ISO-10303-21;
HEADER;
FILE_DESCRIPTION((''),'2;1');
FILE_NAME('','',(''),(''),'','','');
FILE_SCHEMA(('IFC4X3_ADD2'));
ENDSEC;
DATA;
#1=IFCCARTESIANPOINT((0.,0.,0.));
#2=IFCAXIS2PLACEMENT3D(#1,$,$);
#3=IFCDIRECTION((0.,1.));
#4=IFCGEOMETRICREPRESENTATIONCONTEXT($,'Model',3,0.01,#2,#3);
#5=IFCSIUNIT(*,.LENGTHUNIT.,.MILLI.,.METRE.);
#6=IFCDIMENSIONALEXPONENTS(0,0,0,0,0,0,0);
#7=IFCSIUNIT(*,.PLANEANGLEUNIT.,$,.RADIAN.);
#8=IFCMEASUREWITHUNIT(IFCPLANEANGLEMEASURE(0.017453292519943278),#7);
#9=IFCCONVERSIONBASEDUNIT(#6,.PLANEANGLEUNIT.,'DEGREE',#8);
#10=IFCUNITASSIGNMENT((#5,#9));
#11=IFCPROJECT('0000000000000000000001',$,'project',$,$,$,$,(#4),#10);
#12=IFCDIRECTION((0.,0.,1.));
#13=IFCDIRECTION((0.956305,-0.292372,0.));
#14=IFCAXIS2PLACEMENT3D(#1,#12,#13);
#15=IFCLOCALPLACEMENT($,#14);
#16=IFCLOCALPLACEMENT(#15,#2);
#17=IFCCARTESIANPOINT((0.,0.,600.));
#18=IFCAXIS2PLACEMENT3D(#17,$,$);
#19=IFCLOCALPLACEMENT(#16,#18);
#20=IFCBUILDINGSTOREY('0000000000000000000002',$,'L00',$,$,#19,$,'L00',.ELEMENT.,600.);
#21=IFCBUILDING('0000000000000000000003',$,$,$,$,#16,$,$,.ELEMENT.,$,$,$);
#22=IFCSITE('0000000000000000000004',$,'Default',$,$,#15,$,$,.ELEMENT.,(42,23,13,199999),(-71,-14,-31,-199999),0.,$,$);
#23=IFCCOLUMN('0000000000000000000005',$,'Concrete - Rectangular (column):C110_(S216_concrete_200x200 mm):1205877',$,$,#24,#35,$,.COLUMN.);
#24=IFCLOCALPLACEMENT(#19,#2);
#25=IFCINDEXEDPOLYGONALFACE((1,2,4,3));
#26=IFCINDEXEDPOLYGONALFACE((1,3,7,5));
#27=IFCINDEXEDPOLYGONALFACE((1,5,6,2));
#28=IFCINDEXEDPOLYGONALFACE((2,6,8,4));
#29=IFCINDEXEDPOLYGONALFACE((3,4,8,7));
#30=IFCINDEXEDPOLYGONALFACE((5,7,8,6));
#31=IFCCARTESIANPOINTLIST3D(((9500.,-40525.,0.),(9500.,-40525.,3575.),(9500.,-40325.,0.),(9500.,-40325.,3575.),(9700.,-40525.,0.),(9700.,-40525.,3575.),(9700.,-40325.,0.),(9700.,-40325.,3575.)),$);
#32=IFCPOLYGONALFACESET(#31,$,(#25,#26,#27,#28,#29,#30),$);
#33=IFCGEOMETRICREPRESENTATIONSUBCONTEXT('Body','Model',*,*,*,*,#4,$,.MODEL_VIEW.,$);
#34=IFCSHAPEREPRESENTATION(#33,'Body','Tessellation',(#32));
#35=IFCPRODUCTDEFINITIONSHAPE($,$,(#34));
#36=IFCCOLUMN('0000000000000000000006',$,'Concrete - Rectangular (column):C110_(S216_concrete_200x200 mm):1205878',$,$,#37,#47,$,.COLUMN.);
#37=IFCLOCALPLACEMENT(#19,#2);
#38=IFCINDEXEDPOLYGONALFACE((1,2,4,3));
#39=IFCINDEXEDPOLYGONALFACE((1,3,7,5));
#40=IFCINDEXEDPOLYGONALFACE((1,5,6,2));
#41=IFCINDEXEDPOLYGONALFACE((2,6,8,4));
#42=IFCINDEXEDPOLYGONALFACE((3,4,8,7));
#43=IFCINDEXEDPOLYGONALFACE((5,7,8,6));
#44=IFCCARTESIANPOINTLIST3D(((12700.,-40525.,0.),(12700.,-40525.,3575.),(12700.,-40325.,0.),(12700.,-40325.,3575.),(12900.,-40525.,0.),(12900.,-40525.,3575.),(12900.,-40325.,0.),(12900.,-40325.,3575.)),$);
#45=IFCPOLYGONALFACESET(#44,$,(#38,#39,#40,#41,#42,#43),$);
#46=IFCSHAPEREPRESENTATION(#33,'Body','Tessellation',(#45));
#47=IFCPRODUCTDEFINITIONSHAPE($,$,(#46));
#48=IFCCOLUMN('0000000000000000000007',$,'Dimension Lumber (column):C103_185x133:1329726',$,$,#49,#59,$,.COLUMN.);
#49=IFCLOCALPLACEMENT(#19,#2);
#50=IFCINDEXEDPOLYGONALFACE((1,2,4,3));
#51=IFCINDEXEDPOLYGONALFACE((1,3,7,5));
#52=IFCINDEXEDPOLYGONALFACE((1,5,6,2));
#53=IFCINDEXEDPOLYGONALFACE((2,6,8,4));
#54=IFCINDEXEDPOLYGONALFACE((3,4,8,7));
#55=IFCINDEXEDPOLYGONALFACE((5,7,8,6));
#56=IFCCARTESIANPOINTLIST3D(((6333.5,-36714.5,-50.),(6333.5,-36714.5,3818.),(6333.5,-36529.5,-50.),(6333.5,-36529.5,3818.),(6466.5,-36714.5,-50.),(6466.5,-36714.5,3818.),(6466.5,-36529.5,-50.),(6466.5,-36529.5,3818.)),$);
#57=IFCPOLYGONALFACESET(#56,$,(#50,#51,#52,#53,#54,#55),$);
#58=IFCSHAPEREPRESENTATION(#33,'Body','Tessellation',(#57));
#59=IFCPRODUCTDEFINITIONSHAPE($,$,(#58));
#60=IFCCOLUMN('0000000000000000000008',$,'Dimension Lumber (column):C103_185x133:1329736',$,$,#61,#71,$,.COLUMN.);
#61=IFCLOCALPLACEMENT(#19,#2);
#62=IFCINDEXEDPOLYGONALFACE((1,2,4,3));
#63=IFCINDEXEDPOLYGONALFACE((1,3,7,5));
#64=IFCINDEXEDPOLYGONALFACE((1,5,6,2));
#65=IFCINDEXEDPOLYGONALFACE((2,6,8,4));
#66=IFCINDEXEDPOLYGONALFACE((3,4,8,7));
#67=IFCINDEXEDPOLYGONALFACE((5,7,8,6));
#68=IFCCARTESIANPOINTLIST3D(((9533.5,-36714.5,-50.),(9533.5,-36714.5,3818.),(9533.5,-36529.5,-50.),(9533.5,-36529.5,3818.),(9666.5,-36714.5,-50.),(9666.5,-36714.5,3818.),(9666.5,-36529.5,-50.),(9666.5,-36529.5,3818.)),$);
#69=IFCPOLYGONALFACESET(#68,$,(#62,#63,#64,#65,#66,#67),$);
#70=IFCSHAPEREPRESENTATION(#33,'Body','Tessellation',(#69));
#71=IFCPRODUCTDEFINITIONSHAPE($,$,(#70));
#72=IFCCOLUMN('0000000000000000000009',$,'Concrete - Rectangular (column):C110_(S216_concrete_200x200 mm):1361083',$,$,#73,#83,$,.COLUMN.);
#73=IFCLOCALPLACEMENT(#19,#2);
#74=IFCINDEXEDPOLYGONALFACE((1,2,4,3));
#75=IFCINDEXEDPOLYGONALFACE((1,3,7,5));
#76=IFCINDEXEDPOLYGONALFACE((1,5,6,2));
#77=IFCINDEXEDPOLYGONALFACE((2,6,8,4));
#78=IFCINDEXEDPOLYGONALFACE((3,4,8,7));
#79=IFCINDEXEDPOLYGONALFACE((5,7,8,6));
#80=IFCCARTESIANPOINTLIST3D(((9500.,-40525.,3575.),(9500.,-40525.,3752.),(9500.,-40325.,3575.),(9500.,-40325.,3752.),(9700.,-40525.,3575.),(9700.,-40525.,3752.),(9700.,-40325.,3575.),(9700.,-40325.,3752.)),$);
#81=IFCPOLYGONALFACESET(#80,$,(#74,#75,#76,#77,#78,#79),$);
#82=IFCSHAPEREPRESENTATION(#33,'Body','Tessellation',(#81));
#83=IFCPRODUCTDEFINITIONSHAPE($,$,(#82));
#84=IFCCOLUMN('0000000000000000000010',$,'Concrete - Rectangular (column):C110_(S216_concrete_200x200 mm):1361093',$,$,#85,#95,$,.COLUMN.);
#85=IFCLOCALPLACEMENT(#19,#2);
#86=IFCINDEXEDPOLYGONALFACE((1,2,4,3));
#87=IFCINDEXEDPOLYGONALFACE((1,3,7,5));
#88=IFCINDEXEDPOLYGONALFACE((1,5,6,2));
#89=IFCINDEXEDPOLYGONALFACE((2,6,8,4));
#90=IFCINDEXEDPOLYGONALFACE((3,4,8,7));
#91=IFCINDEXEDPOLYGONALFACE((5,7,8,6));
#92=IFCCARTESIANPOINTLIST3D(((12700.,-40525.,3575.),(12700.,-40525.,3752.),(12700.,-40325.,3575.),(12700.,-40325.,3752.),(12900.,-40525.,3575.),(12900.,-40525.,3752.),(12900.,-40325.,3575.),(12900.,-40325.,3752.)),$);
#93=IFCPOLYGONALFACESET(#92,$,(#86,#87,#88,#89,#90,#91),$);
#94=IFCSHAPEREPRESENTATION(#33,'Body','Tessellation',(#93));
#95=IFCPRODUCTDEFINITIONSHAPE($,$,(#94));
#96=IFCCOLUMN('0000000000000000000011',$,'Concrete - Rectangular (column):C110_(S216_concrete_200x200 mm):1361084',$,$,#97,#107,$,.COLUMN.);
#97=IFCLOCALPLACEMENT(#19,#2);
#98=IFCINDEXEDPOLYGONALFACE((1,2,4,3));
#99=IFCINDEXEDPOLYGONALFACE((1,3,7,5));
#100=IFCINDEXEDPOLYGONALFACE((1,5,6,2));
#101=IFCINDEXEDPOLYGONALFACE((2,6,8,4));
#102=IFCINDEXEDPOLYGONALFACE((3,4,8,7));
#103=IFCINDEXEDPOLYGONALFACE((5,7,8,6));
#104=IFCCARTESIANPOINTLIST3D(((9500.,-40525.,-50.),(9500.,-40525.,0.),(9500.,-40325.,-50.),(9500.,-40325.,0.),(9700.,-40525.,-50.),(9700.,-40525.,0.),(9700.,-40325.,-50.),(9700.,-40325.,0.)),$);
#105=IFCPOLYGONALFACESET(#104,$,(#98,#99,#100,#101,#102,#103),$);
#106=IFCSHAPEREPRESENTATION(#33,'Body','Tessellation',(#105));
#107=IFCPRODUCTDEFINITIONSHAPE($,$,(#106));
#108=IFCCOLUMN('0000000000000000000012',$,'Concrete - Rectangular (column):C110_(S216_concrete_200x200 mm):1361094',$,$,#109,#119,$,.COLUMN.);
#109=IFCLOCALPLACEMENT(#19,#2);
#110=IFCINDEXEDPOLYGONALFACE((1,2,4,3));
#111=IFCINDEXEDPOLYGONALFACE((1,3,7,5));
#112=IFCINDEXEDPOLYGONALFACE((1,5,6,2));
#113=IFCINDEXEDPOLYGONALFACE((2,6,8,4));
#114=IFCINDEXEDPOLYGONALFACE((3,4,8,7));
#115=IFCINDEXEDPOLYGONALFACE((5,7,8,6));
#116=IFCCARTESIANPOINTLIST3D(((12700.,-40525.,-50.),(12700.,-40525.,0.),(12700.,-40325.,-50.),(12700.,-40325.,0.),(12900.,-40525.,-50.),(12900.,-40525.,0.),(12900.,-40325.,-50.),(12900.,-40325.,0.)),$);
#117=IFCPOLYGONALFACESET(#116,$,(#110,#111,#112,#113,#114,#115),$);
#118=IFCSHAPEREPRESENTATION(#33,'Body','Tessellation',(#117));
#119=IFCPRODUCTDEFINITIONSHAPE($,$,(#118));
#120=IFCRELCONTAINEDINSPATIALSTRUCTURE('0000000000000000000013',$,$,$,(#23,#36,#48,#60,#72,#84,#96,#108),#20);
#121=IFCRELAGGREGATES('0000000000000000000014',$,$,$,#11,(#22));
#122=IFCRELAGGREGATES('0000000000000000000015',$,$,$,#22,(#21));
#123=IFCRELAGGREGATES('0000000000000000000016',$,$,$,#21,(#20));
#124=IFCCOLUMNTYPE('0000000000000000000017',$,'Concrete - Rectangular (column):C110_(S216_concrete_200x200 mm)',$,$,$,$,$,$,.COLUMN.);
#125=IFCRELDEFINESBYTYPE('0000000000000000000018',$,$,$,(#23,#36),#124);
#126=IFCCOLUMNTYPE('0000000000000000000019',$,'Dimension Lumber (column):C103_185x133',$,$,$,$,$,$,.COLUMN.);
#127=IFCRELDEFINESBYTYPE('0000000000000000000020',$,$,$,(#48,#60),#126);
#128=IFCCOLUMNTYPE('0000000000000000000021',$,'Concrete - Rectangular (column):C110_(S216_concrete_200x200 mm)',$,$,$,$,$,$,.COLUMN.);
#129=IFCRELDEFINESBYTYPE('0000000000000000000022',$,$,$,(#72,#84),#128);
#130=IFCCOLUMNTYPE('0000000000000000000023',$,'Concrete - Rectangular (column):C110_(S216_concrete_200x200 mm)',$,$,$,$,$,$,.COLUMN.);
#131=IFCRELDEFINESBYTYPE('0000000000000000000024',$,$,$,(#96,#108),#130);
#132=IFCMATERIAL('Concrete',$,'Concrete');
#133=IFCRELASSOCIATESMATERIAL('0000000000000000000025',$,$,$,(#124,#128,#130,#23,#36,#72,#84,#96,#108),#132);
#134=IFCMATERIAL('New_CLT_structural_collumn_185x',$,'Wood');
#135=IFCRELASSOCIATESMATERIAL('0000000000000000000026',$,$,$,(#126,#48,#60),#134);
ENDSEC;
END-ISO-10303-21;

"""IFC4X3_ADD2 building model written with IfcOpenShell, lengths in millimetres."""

from ifc_helpers import new_model, entity, si_unit, converted_unit, direction, frame, origin, origin_2d_with_axis, place, context, subcontext, project, spatial, rectangle, extrude, source, transform, mapped, material, material_profile, profile_set, profile_usage, type_object, type_shapes, element, save


model = new_model("IFC4X3_ADD2")

# Units and contexts
model_context = context("Model", 3, precision=0.01, world=origin(), true_north=direction((0.0, 1.0)))
body_context = subcontext(model_context, "Body", "Model", "MODEL_VIEW")
ifc_project = project(units=[si_unit("LENGTHUNIT", "METRE", prefix="MILLI"), converted_unit("PLANEANGLEUNIT", "DEGREE", entity("IfcPlaneAngleMeasure", 0.017453292519943278), si_unit("PLANEANGLEUNIT", "RADIAN"), dimensions=[0, 0, 0, 0, 0, 0, 0])], contexts=[model_context])

# Site, building, storey
site_placement = place(None, frame((0.0, 0.0, 0.0), z_axis=(0.0, 0.0, 1.0), x_axis=(0.956305, -0.292372, 0.0)))
site = spatial("IfcSite", under=ifc_project, at=site_placement, Name="Default", CompositionType="ELEMENT", RefLatitude=(42, 23, 13, 199999), RefLongitude=(-71, -14, -31, -199999), RefElevation=0.0)
building_placement = place(site_placement, origin())
building = spatial("IfcBuilding", under=site, at=building_placement, CompositionType="ELEMENT")
storey_placement = place(building_placement, frame((0.0, 0.0, 600.0)))
storey = spatial("IfcBuildingStorey", under=building, at=storey_placement, Name="L00", LongName="L00", CompositionType="ELEMENT", Elevation=600.0)

# Columns
ifc_material_1 = material(Name="Concrete", Category="Concrete")
ifc_material_profile_1 = material_profile(ifc_material_1, rectangle(XDim=200.0, YDim=200.0, at=origin_2d_with_axis()), Name="C110_(S216_concrete_200x200 mm)")
ifc_profile_set_1 = profile_set([ifc_material_profile_1], Name="C110_(S216_concrete_200x200 mm)")
ifc_profile_usage_1 = profile_usage(ifc_profile_set_1)
column_type_1 = type_object("IfcColumnType", Name="Concrete - Rectangular (column):C110_(S216_concrete_200x200 mm)", PredefinedType="COLUMN", material=ifc_profile_set_1)
shared_shape_1 = source(origin(), body_context, "Body", "SweptSolid", [
    extrude(rectangle(XDim=200.0, YDim=200.0, at=origin_2d_with_axis()), frame((0.0, 0.0, 600.0), z_axis=(0.0, 0.0, 1.0), x_axis=(-1.0, 0.0, 0.0)), (0.0, 0.0, 1.0), 3575.0),
])
type_shapes(column_type_1, [shared_shape_1])
for number, where, name in (
    (1, (9600.0, -40425.0, -600.0), "Concrete - Rectangular (column):C110_(S216_concrete_200x200 mm):1205877"),
    (2, (12800.0, -40425.0, -600.0), "Concrete - Rectangular (column):C110_(S216_concrete_200x200 mm):1205878"),
):
    element("IfcColumn", number, at=place(storey_placement, frame(where)), inside=storey, type_object=column_type_1, material=ifc_profile_usage_1, Name=name, PredefinedType="COLUMN", context=body_context, shape_type="MappedRepresentation", body=[
        mapped(shared_shape_1, transform((0.0, 0.0, 0.0), scale=1.0)),
    ])
ifc_material_2 = material(Name="New_CLT_structural_collumn_185x", Category="Wood")
ifc_material_profile_2 = material_profile(ifc_material_2, rectangle(XDim=185.0, YDim=133.0, at=origin_2d_with_axis()), Name="C103_185x133")
ifc_profile_set_2 = profile_set([ifc_material_profile_2], Name="C103_185x133")
ifc_profile_usage_2 = profile_usage(ifc_profile_set_2)
column_type_2 = type_object("IfcColumnType", Name="Dimension Lumber (column):C103_185x133", PredefinedType="COLUMN", material=ifc_profile_set_2)
shared_shape_2 = source(origin(), body_context, "Body", "SweptSolid", [
    extrude(rectangle(XDim=185.0, YDim=133.0, at=origin_2d_with_axis()), frame((0.0, 0.0, 550.0), z_axis=(0.0, 0.0, 1.0), x_axis=(-1.0, 0.0, 0.0)), (0.0, 0.0, 1.0), 3868.0),
])
type_shapes(column_type_2, [shared_shape_2])
for number, where, z_axis, x_axis, name in (
    (3, (6400.0, -36622.0, -600.0), (0.0, 0.0, 1.0), (0.0, -1.0, 0.0), "Dimension Lumber (column):C103_185x133:1329726"),
    (4, (9600.0, -36622.0, -600.0), (0.0, 0.0, 1.0), (0.0, -1.0, 0.0), "Dimension Lumber (column):C103_185x133:1329736"),
):
    element("IfcColumn", number, at=place(storey_placement, frame(where, z_axis=z_axis, x_axis=x_axis)), inside=storey, type_object=column_type_2, material=ifc_profile_usage_2, Name=name, PredefinedType="COLUMN", context=body_context, shape_type="MappedRepresentation", body=[
        mapped(shared_shape_2, transform((0.0, 0.0, 0.0), scale=1.0)),
    ])
column_type_3 = type_object("IfcColumnType", Name="Concrete - Rectangular (column):C110_(S216_concrete_200x200 mm)", PredefinedType="COLUMN", material=ifc_profile_set_1)
shared_shape_3 = source(origin(), body_context, "Body", "SweptSolid", [
    extrude(rectangle(XDim=200.0, YDim=200.0, at=origin_2d_with_axis()), frame((0.0, 0.0, 4175.0), z_axis=(0.0, 0.0, 1.0), x_axis=(-1.0, 0.0, 0.0)), (0.0, 0.0, 1.0), 177.0),
])
type_shapes(column_type_3, [shared_shape_3])
for number, where, name in (
    (5, (9600.0, -40425.0, -600.0), "Concrete - Rectangular (column):C110_(S216_concrete_200x200 mm):1361083"),
    (6, (12800.0, -40425.0, -600.0), "Concrete - Rectangular (column):C110_(S216_concrete_200x200 mm):1361093"),
):
    element("IfcColumn", number, at=place(storey_placement, frame(where)), inside=storey, type_object=column_type_3, material=ifc_profile_usage_1, Name=name, PredefinedType="COLUMN", context=body_context, shape_type="MappedRepresentation", body=[
        mapped(shared_shape_3, transform((0.0, 0.0, 0.0), scale=1.0)),
    ])
column_type_4 = type_object("IfcColumnType", Name="Concrete - Rectangular (column):C110_(S216_concrete_200x200 mm)", PredefinedType="COLUMN", material=ifc_profile_set_1)
shared_shape_4 = source(origin(), body_context, "Body", "SweptSolid", [
    extrude(rectangle(XDim=200.0, YDim=200.0, at=origin_2d_with_axis()), frame((0.0, 0.0, 550.0), z_axis=(0.0, 0.0, 1.0), x_axis=(-1.0, 0.0, 0.0)), (0.0, 0.0, 1.0), 50.0),
])
type_shapes(column_type_4, [shared_shape_4])
for number, where, name in (
    (7, (9600.0, -40425.0, -600.0), "Concrete - Rectangular (column):C110_(S216_concrete_200x200 mm):1361084"),
    (8, (12800.0, -40425.0, -600.0), "Concrete - Rectangular (column):C110_(S216_concrete_200x200 mm):1361094"),
):
    element("IfcColumn", number, at=place(storey_placement, frame(where)), inside=storey, type_object=column_type_4, material=ifc_profile_usage_1, Name=name, PredefinedType="COLUMN", context=body_context, shape_type="MappedRepresentation", body=[
        mapped(shared_shape_4, transform((0.0, 0.0, 0.0), scale=1.0)),
    ])

save(model, "model.ifc")
